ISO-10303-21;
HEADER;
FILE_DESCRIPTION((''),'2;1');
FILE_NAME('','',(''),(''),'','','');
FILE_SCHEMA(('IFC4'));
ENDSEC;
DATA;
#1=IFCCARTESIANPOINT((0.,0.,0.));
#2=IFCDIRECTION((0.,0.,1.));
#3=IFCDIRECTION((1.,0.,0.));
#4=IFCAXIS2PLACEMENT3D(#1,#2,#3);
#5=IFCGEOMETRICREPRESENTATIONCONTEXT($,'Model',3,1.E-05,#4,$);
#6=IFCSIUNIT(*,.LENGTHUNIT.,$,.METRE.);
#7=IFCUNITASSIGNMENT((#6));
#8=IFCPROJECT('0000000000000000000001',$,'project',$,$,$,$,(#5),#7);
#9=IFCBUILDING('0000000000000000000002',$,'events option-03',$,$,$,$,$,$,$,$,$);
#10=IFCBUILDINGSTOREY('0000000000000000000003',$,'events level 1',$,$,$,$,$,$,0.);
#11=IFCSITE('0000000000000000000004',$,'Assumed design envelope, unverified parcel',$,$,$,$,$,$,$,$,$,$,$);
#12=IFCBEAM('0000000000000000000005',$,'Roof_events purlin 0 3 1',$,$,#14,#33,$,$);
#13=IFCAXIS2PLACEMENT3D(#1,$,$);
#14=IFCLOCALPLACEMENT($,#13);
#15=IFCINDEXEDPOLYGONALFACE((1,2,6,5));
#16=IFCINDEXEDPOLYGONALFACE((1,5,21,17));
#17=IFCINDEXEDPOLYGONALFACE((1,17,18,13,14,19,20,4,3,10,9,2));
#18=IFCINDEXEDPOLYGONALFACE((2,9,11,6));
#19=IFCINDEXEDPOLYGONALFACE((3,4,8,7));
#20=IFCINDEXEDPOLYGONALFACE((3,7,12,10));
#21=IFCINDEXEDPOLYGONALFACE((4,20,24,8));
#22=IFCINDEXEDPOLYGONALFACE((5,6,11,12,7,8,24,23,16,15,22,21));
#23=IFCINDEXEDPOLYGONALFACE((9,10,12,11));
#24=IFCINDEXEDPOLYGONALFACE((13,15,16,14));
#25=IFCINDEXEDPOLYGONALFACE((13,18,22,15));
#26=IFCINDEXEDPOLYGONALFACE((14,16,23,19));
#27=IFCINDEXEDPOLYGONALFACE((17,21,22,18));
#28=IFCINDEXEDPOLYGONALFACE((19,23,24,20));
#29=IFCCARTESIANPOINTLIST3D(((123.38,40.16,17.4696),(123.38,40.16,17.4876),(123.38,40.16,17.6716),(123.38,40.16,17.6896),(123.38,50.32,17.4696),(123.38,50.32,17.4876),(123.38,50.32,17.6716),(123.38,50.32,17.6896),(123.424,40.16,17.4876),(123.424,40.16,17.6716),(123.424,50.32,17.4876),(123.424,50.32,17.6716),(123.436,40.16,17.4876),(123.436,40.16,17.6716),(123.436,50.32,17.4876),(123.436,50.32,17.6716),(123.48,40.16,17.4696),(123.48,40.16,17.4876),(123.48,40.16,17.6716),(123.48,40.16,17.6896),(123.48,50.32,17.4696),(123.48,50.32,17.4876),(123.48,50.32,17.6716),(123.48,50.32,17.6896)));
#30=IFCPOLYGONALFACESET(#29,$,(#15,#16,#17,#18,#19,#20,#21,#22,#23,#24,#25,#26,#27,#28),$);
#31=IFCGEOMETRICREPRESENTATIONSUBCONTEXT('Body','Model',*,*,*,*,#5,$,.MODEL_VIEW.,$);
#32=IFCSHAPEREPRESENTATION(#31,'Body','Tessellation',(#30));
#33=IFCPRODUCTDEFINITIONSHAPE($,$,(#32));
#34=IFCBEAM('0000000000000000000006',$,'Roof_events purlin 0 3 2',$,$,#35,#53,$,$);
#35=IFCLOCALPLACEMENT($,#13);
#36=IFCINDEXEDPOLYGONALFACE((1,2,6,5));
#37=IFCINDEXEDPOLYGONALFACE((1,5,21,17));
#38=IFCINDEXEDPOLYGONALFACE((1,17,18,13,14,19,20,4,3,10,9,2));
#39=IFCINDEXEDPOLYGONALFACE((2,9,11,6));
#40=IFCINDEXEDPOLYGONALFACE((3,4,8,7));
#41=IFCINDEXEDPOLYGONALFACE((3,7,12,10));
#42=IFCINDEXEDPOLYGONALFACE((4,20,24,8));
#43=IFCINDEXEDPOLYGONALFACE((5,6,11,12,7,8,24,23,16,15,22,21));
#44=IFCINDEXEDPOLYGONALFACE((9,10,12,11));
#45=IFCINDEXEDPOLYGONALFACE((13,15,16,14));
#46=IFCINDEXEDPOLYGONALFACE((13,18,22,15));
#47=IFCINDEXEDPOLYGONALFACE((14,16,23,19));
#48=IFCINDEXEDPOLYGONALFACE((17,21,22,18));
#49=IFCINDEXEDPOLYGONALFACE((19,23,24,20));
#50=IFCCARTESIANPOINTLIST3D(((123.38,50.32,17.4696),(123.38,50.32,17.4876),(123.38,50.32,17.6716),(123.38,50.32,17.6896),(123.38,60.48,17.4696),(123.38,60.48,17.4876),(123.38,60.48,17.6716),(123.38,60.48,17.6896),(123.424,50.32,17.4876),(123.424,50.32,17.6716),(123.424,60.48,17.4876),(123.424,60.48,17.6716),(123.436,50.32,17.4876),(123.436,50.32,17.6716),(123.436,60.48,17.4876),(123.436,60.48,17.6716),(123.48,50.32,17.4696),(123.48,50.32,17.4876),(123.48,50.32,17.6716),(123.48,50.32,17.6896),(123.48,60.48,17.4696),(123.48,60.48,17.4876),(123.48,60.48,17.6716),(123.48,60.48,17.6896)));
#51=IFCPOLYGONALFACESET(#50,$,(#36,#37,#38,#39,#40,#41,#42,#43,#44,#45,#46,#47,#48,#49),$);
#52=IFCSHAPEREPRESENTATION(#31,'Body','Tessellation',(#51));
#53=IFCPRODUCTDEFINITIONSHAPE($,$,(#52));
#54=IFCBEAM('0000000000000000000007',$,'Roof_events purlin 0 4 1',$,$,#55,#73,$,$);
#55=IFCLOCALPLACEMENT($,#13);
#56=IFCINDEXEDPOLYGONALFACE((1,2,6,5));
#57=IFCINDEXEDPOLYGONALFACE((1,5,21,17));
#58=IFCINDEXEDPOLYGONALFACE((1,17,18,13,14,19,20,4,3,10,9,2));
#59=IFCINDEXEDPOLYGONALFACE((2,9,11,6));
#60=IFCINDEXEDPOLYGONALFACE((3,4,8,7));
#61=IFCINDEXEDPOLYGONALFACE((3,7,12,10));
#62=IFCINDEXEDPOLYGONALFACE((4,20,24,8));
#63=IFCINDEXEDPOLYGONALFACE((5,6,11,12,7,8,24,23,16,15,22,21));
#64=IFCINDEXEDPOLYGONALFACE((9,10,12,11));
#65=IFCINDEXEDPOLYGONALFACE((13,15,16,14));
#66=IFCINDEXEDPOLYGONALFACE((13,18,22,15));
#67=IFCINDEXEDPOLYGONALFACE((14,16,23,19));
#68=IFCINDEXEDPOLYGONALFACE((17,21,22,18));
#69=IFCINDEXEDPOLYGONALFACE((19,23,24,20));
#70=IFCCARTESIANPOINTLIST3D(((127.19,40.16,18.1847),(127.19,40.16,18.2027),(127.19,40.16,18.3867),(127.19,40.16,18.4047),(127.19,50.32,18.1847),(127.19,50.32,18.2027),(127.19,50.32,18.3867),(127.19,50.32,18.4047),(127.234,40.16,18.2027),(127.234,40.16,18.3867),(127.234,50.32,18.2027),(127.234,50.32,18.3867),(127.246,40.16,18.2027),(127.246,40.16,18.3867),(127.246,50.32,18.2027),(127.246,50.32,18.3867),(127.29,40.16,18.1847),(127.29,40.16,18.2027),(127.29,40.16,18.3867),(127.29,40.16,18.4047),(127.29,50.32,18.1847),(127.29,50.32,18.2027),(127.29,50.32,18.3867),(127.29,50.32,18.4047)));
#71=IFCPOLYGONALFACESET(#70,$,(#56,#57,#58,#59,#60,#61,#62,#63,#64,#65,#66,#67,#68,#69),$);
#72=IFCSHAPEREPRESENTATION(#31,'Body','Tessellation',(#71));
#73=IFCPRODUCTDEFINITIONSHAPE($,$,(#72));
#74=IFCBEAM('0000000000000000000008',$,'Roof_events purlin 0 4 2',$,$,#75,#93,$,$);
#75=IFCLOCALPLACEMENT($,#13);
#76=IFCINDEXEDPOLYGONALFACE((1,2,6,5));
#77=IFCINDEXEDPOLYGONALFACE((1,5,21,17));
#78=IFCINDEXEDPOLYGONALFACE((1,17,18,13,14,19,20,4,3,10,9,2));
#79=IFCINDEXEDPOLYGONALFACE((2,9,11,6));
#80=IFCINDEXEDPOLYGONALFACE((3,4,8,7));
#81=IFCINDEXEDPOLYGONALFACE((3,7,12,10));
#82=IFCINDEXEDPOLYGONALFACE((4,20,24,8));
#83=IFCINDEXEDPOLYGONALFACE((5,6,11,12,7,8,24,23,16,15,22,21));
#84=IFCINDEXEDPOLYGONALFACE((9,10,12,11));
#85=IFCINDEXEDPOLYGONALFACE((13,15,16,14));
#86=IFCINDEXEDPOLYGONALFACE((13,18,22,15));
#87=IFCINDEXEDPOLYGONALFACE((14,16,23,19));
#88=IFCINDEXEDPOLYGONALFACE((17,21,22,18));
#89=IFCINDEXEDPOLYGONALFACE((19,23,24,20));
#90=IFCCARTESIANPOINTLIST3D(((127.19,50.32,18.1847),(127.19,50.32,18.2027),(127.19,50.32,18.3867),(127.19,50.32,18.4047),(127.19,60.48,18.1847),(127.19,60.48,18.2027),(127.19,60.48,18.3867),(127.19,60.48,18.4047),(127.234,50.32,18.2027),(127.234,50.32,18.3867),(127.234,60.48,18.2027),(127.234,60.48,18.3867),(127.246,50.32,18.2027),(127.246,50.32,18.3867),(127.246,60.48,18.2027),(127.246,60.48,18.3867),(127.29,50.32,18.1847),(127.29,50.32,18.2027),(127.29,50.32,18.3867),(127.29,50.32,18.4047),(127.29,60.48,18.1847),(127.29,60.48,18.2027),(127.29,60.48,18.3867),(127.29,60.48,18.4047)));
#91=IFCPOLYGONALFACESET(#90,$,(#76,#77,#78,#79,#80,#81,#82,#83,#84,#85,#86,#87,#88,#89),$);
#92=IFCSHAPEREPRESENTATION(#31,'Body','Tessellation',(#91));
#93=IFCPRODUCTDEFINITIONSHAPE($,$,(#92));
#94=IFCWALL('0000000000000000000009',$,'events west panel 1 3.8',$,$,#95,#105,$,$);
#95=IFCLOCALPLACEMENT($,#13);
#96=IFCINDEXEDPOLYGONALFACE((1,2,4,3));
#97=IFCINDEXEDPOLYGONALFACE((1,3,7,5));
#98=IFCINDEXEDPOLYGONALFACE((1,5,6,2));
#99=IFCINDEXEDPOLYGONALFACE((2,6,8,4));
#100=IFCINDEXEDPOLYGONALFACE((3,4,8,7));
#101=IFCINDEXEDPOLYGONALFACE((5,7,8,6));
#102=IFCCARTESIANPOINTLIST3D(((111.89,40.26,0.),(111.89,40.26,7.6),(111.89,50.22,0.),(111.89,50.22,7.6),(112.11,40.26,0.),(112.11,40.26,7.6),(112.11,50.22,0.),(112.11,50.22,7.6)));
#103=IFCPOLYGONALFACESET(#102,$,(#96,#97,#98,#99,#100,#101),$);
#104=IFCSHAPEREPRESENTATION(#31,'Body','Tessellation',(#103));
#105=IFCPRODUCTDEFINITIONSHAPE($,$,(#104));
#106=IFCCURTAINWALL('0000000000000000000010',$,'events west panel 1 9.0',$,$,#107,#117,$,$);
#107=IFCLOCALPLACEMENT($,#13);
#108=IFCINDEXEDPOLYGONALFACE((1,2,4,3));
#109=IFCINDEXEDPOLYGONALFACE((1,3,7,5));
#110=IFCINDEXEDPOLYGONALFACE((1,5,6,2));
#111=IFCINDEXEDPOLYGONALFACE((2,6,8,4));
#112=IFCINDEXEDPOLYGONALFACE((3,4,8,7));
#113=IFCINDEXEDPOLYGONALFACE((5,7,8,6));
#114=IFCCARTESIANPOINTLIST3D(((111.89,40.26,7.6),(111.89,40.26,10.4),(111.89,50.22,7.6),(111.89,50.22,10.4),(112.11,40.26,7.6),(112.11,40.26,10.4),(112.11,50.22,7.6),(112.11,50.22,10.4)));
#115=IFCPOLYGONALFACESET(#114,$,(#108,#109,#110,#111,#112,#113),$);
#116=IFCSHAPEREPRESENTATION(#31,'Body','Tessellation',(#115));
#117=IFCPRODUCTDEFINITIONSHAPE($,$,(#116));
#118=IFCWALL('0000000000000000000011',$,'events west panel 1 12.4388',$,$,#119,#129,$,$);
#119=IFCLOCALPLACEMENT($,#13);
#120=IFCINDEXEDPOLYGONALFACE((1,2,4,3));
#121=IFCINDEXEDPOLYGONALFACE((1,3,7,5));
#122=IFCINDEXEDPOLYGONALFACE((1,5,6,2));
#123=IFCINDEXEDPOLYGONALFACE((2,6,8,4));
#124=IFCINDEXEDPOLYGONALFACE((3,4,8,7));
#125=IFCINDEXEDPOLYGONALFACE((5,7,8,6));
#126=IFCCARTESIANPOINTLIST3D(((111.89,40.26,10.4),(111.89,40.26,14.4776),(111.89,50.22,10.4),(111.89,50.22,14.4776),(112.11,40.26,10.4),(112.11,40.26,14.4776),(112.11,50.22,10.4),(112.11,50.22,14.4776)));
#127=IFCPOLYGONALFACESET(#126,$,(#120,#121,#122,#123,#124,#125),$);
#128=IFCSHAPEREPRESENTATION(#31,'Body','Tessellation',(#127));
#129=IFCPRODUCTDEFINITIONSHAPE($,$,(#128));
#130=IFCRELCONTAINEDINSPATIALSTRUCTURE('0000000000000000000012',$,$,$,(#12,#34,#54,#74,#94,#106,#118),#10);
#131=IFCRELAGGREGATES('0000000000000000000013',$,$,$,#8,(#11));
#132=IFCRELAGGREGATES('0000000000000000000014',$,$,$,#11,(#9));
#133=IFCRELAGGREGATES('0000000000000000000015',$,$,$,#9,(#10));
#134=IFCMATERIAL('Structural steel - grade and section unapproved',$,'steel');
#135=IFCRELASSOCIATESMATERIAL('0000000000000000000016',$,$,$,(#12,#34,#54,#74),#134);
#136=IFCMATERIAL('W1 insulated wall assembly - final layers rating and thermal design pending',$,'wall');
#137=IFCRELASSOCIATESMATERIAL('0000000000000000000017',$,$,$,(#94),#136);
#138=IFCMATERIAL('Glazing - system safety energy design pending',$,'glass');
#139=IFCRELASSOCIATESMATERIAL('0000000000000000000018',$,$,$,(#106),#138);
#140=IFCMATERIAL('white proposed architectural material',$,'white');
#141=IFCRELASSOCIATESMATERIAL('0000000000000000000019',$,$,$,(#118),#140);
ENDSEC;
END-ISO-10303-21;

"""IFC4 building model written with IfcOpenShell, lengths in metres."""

from ifc_helpers import new_model, si_unit, frame, origin_with_axes, place, context, subcontext, project, spatial, rectangle, i_section, extrude, material, element, save


model = new_model("IFC4")

# Units and contexts
model_context = context("Model", 3, precision=1e-05, world=origin_with_axes())
body_context = subcontext(model_context, "Body", "Model", "MODEL_VIEW")
ifc_project = project(units=[si_unit("LENGTHUNIT", "METRE")], contexts=[model_context])

# Site, building, storey
site = spatial("IfcSite", under=ifc_project, Name="Assumed design envelope, unverified parcel")
building = spatial("IfcBuilding", under=site, Name="events option-03")
storey = spatial("IfcBuildingStorey", under=building, Name="events level 1", Elevation=0.0)

# Shared definitions
ifc_material_1 = material(Name="Structural steel - grade and section unapproved", Category="steel")

# Beams
for number, where, z_axis, x_axis, name in (
    (1, (123.43, 40.16, 17.5796), (0.0, 1.0, 0.0), (-1.0, 0.0, 0.0), "Roof_events purlin 0 3 1"),
    (2, (123.43, 50.32, 17.5796), (0.0, 1.0, 0.0), (-1.0, 0.0, 0.0), "Roof_events purlin 0 3 2"),
    (3, (127.24, 40.16, 18.2947), (0.0, 1.0, 0.0), (-1.0, 0.0, 0.0), "Roof_events purlin 0 4 1"),
    (4, (127.24, 50.32, 18.2947), (0.0, 1.0, 0.0), (-1.0, 0.0, 0.0), "Roof_events purlin 0 4 2"),
):
    element("IfcBeam", number, at=place(None, frame(where, z_axis=z_axis, x_axis=x_axis)), inside=storey, material=ifc_material_1, Name=name, context=body_context, shape_type="SweptSolid", body=[
        extrude(i_section(OverallWidth=0.1, OverallDepth=0.22, WebThickness=0.012, FlangeThickness=0.018, FilletRadius=0.0), origin_with_axes(), (0.0, 0.0, 1.0), 10.16),
    ])

# Wall
ifc_material_2 = material(Name="W1 insulated wall assembly - final layers rating and thermal design pending", Category="wall")
wall_1_placement = place(None, frame((112.0, 45.24, 0.0), z_axis=(0.0, 0.0, 1.0), x_axis=(1.0, 0.0, 0.0)))
element("IfcWall", 5, at=wall_1_placement, inside=storey, material=ifc_material_2, Name="events west panel 1 3.8", context=body_context, shape_type="SweptSolid", body=[
    extrude(rectangle(XDim=0.22, YDim=9.96), origin_with_axes(), (0.0, 0.0, 1.0), 7.6),
])

# Curtain wall
ifc_material_3 = material(Name="Glazing - system safety energy design pending", Category="glass")
curtain_wall_placement = place(None, frame((112.0, 45.24, 7.6), z_axis=(0.0, 0.0, 1.0), x_axis=(1.0, 0.0, 0.0)))
element("IfcCurtainWall", 6, at=curtain_wall_placement, inside=storey, material=ifc_material_3, Name="events west panel 1 9.0", context=body_context, shape_type="SweptSolid", body=[
    extrude(rectangle(XDim=0.22, YDim=9.96), origin_with_axes(), (0.0, 0.0, 1.0), 2.8),
])

# Wall
ifc_material_4 = material(Name="white proposed architectural material", Category="white")
wall_2_placement = place(None, frame((112.0, 45.24, 10.4), z_axis=(0.0, 0.0, 1.0), x_axis=(1.0, 0.0, 0.0)))
element("IfcWall", 7, at=wall_2_placement, inside=storey, material=ifc_material_4, Name="events west panel 1 12.4388", context=body_context, shape_type="SweptSolid", body=[
    extrude(rectangle(XDim=0.22, YDim=9.96), origin_with_axes(), (0.0, 0.0, 1.0), 4.0776),
])

save(model, "model.ifc")
